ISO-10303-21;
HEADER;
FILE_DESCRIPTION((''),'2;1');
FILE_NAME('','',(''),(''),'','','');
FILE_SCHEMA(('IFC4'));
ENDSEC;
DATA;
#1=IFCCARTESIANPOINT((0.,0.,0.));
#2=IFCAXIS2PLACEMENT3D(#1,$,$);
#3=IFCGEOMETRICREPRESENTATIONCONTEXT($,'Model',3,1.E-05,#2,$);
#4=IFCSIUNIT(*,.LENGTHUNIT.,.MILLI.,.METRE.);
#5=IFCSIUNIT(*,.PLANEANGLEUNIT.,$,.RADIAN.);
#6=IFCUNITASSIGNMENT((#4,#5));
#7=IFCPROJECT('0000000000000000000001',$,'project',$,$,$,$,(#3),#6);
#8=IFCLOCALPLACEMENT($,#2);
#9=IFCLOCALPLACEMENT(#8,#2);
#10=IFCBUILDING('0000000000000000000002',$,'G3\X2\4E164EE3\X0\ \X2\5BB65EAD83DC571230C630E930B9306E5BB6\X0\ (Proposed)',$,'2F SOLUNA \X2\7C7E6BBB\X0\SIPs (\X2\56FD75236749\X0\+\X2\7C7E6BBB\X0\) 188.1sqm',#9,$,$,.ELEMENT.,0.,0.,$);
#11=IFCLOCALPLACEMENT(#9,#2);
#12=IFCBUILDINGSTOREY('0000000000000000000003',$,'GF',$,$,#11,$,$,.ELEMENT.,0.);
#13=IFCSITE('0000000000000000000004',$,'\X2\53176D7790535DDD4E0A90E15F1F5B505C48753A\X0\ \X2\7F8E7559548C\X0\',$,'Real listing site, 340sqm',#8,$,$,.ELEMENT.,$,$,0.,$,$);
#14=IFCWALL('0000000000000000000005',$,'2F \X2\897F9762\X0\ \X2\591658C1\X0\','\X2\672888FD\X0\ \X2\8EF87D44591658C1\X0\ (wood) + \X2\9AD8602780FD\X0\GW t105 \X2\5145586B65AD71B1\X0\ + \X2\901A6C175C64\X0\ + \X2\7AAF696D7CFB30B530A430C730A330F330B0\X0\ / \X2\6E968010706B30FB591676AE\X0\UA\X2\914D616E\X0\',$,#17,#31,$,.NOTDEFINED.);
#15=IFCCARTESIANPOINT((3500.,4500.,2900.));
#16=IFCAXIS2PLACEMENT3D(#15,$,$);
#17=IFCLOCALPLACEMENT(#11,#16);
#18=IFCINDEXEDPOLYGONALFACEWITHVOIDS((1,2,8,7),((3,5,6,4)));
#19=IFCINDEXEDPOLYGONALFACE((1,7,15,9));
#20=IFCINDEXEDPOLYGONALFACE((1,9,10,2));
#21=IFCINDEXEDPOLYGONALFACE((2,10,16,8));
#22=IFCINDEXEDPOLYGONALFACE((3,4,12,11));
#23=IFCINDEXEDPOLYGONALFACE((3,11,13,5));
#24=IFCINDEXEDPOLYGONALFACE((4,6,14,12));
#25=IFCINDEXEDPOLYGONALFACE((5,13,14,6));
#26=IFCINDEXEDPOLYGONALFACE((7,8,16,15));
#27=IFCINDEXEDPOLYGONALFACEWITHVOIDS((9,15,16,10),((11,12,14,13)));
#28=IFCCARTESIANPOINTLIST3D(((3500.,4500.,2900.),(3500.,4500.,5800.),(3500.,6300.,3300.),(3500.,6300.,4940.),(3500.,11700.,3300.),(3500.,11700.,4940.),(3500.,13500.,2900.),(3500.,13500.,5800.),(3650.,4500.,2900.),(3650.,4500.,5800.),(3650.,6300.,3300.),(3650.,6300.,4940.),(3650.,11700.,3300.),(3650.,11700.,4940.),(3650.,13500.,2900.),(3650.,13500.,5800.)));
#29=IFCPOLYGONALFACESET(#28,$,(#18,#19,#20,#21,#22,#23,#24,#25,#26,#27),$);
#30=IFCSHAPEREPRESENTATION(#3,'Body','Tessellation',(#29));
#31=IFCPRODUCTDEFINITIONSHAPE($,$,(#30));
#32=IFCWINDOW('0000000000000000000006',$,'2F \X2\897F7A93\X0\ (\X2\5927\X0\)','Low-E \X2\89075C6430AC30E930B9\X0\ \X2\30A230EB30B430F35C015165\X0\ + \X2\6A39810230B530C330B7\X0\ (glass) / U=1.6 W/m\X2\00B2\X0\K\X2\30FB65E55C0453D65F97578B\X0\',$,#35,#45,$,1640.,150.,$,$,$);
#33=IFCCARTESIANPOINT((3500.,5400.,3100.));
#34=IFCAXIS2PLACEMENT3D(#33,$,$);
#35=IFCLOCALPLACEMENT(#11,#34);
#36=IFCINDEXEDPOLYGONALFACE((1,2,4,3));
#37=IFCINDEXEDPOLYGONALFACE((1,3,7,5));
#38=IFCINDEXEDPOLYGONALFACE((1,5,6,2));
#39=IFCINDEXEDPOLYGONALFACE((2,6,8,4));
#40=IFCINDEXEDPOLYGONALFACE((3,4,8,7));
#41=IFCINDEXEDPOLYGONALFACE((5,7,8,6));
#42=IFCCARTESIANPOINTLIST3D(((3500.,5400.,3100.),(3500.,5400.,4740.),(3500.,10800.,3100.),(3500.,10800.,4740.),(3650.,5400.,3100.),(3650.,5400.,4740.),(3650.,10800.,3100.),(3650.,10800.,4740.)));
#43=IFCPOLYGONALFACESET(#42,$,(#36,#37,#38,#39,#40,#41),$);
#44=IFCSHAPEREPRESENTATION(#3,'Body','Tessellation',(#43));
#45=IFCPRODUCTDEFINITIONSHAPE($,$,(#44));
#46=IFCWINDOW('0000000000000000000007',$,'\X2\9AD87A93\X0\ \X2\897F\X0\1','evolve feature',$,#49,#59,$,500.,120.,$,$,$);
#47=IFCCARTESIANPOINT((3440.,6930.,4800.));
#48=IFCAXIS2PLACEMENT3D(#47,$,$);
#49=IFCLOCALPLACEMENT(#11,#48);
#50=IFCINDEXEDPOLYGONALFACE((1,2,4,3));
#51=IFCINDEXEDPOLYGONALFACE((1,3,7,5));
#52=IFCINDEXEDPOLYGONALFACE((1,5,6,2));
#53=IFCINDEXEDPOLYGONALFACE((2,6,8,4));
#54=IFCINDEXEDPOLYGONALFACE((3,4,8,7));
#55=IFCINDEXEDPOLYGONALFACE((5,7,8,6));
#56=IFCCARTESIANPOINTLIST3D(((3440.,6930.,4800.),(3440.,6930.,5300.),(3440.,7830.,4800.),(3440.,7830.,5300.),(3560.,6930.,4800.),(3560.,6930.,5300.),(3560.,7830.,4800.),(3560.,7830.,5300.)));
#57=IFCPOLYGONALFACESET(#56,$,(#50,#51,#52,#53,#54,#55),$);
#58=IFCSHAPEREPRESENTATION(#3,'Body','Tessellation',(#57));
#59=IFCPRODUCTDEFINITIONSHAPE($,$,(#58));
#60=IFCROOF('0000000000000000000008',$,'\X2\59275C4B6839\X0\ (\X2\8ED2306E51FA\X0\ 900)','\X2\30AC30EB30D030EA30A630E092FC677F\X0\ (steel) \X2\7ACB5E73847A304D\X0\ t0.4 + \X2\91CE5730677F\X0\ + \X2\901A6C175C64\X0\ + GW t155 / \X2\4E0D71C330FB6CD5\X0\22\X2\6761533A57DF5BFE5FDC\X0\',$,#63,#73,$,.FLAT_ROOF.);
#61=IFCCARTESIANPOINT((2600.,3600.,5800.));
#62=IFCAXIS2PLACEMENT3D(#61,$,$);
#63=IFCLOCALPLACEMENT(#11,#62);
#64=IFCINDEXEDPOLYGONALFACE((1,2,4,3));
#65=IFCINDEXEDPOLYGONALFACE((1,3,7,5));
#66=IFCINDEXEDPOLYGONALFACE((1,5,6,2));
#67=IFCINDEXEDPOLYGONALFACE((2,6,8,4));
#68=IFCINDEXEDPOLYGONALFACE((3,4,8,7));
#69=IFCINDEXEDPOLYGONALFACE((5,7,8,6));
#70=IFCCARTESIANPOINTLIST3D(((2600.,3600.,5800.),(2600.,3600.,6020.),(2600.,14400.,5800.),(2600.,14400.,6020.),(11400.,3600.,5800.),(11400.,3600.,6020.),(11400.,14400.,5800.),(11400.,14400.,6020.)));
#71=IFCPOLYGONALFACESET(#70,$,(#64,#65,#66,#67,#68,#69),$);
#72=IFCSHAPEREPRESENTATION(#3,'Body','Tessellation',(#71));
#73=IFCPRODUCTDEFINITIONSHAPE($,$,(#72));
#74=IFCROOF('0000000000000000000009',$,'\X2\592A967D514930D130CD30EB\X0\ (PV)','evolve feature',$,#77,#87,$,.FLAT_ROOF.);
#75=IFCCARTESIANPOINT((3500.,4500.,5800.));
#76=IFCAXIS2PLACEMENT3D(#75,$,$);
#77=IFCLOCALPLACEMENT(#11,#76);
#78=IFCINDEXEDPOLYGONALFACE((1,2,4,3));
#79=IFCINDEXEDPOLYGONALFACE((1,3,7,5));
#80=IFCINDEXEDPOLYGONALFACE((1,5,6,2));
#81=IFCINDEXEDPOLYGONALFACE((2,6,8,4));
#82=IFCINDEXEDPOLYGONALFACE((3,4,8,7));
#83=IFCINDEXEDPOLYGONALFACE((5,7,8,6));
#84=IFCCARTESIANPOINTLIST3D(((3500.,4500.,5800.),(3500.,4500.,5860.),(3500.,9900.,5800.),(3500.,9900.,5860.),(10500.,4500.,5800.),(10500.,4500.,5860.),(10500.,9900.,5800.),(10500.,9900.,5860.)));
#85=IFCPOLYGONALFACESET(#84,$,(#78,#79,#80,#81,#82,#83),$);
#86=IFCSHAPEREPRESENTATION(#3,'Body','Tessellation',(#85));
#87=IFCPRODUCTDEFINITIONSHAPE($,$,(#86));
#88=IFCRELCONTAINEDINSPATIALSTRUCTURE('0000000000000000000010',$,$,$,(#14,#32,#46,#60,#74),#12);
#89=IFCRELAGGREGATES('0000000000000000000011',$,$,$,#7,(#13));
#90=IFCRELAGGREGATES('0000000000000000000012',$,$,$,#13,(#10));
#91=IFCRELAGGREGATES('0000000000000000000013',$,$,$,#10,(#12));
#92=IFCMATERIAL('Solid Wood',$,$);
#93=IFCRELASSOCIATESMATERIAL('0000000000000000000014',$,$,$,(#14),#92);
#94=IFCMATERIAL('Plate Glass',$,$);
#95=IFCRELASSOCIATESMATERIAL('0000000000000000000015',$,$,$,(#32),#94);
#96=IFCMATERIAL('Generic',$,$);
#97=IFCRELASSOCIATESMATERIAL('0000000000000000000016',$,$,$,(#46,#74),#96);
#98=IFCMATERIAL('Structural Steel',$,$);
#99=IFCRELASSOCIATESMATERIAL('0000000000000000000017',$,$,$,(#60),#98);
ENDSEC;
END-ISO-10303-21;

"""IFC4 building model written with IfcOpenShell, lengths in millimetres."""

from ifc_helpers import new_model, si_unit, frame, frame_2d, origin, place, context, project, spatial, rectangle, extrude, material, element, fill, save


model = new_model("IFC4")

# Units and contexts
model_context = context("Model", 3, precision=1e-05, world=origin())
ifc_project = project(units=[si_unit("LENGTHUNIT", "METRE", prefix="MILLI"), si_unit("PLANEANGLEUNIT", "RADIAN")], contexts=[model_context])

# Site, building, storey
site_placement = place(None, origin())
site = spatial("IfcSite", under=ifc_project, at=site_placement, Name="北海道川上郡弟子屈町 美留和", ObjectType="Real listing site, 340sqm", CompositionType="ELEMENT", RefElevation=0.0)
building_placement = place(site_placement, origin())
building = spatial("IfcBuilding", under=site, at=building_placement, Name="G3世代 家庭菜園テラスの家 (Proposed)", ObjectType="2F SOLUNA 籾殻SIPs (国産杉+籾殻) 188.1sqm", CompositionType="ELEMENT", ElevationOfRefHeight=0.0, ElevationOfTerrain=0.0)
storey_placement = place(building_placement, origin())
storey = spatial("IfcBuildingStorey", under=building, at=storey_placement, Name="GF", CompositionType="ELEMENT", Elevation=0.0)

# Shared definitions
ifc_material_1 = material(Name="Solid Wood")
ifc_material_2 = material(Name="Generic")

# Shared definitions
ifc_material_3 = material(Name="Plate Glass")

# Wall, openings, windows
wall_1_placement = place(storey_placement, frame((3500.0, 4500.0, 2900.0)))
wall_1 = element("IfcWall", 1, at=wall_1_placement, inside=storey, material=ifc_material_1, Name="2F 西面 外壁", Description="木製 軸組外壁 (wood) + 高性能GW t105 充填断熱 + 通気層 + 窯業系サイディング / 準耐火・外皮UA配慮", PredefinedType="NOTDEFINED", context=model_context, shape_type="SweptSolid", body=[
    extrude(rectangle(XDim=150.0, YDim=9000.0, at=frame_2d((75.0, 4500.0))), frame((3500.0, 4500.0, 2900.0)), (0.0, 0.0, 1.0), 2900.0),
])
opening_1_placement = place(storey_placement, frame((3500.0, 5400.0, 3100.0)))
opening_1 = element("IfcOpeningElement", 2, at=opening_1_placement, cuts=wall_1, PredefinedType="NOTDEFINED", context=model_context, shape_type="SweptSolid", body=[
    extrude(rectangle(XDim=150.0, YDim=5400.0, at=frame_2d((75.0, 2700.0))), frame((3500.0, 5400.0, 3100.0)), (0.0, 0.0, 1.0), 1640.0),
])
opening_2_placement = place(storey_placement, frame((3440.0, 6930.0, 4800.0)))
opening_2 = element("IfcOpeningElement", 3, at=opening_2_placement, cuts=wall_1, PredefinedType="NOTDEFINED", context=model_context, shape_type="SweptSolid", body=[
    extrude(rectangle(XDim=120.0, YDim=900.0, at=frame_2d((60.0, 450.0))), frame((3440.0, 6930.0, 4800.0)), (0.0, 0.0, 1.0), 500.0),
])
window_1_placement = place(storey_placement, frame((3500.0, 5400.0, 3100.0)))
window_1 = element("IfcWindow", 4, at=window_1_placement, inside=storey, material=ifc_material_3, Name="2F 西窓 (大)", Description="Low-E 複層ガラス アルゴン封入 + 樹脂サッシ (glass) / U=1.6 W/m²K・日射取得型", OverallHeight=1640.0, OverallWidth=150.0, context=model_context, shape_type="SweptSolid", body=[
    extrude(rectangle(XDim=150.0, YDim=5400.0, at=frame_2d((75.0, 2700.0))), frame((3500.0, 5400.0, 3100.0)), (0.0, 0.0, 1.0), 1640.0),
])
fill(opening_1, window_1)
window_2_placement = place(storey_placement, frame((3440.0, 6930.0, 4800.0)))
window_2 = element("IfcWindow", 5, at=window_2_placement, inside=storey, material=ifc_material_2, Name="高窓 西1", Description="evolve feature", OverallHeight=500.0, OverallWidth=120.0, context=model_context, shape_type="SweptSolid", body=[
    extrude(rectangle(XDim=120.0, YDim=900.0, at=frame_2d((60.0, 450.0))), frame((3440.0, 6930.0, 4800.0)), (0.0, 0.0, 1.0), 500.0),
])
fill(opening_2, window_2)

# Roofs
ifc_material_4 = material(Name="Structural Steel")
roof_1_placement = place(storey_placement, frame((2600.0, 3600.0, 5800.0)))
element("IfcRoof", 6, at=roof_1_placement, inside=storey, material=ifc_material_4, Name="大屋根 (軒の出 900)", Description="ガルバリウム鋼板 (steel) 立平葺き t0.4 + 野地板 + 通気層 + GW t155 / 不燃・法22条区域対応", PredefinedType="FLAT_ROOF", context=model_context, shape_type="SweptSolid", body=[
    extrude(rectangle(XDim=8800.0, YDim=10800.0, at=frame_2d((4400.0, 5400.0))), frame((2600.0, 3600.0, 5800.0)), (0.0, 0.0, 1.0), 220.0),
])
roof_2_placement = place(storey_placement, frame((3500.0, 4500.0, 5800.0)))
element("IfcRoof", 7, at=roof_2_placement, inside=storey, material=ifc_material_2, Name="太陽光パネル (PV)", Description="evolve feature", PredefinedType="FLAT_ROOF", context=model_context, shape_type="SweptSolid", body=[
    extrude(rectangle(XDim=7000.0, YDim=5400.0, at=frame_2d((3500.0, 2700.0))), frame((3500.0, 4500.0, 5800.0)), (0.0, 0.0, 1.0), 60.0),
])

save(model, "model.ifc")
